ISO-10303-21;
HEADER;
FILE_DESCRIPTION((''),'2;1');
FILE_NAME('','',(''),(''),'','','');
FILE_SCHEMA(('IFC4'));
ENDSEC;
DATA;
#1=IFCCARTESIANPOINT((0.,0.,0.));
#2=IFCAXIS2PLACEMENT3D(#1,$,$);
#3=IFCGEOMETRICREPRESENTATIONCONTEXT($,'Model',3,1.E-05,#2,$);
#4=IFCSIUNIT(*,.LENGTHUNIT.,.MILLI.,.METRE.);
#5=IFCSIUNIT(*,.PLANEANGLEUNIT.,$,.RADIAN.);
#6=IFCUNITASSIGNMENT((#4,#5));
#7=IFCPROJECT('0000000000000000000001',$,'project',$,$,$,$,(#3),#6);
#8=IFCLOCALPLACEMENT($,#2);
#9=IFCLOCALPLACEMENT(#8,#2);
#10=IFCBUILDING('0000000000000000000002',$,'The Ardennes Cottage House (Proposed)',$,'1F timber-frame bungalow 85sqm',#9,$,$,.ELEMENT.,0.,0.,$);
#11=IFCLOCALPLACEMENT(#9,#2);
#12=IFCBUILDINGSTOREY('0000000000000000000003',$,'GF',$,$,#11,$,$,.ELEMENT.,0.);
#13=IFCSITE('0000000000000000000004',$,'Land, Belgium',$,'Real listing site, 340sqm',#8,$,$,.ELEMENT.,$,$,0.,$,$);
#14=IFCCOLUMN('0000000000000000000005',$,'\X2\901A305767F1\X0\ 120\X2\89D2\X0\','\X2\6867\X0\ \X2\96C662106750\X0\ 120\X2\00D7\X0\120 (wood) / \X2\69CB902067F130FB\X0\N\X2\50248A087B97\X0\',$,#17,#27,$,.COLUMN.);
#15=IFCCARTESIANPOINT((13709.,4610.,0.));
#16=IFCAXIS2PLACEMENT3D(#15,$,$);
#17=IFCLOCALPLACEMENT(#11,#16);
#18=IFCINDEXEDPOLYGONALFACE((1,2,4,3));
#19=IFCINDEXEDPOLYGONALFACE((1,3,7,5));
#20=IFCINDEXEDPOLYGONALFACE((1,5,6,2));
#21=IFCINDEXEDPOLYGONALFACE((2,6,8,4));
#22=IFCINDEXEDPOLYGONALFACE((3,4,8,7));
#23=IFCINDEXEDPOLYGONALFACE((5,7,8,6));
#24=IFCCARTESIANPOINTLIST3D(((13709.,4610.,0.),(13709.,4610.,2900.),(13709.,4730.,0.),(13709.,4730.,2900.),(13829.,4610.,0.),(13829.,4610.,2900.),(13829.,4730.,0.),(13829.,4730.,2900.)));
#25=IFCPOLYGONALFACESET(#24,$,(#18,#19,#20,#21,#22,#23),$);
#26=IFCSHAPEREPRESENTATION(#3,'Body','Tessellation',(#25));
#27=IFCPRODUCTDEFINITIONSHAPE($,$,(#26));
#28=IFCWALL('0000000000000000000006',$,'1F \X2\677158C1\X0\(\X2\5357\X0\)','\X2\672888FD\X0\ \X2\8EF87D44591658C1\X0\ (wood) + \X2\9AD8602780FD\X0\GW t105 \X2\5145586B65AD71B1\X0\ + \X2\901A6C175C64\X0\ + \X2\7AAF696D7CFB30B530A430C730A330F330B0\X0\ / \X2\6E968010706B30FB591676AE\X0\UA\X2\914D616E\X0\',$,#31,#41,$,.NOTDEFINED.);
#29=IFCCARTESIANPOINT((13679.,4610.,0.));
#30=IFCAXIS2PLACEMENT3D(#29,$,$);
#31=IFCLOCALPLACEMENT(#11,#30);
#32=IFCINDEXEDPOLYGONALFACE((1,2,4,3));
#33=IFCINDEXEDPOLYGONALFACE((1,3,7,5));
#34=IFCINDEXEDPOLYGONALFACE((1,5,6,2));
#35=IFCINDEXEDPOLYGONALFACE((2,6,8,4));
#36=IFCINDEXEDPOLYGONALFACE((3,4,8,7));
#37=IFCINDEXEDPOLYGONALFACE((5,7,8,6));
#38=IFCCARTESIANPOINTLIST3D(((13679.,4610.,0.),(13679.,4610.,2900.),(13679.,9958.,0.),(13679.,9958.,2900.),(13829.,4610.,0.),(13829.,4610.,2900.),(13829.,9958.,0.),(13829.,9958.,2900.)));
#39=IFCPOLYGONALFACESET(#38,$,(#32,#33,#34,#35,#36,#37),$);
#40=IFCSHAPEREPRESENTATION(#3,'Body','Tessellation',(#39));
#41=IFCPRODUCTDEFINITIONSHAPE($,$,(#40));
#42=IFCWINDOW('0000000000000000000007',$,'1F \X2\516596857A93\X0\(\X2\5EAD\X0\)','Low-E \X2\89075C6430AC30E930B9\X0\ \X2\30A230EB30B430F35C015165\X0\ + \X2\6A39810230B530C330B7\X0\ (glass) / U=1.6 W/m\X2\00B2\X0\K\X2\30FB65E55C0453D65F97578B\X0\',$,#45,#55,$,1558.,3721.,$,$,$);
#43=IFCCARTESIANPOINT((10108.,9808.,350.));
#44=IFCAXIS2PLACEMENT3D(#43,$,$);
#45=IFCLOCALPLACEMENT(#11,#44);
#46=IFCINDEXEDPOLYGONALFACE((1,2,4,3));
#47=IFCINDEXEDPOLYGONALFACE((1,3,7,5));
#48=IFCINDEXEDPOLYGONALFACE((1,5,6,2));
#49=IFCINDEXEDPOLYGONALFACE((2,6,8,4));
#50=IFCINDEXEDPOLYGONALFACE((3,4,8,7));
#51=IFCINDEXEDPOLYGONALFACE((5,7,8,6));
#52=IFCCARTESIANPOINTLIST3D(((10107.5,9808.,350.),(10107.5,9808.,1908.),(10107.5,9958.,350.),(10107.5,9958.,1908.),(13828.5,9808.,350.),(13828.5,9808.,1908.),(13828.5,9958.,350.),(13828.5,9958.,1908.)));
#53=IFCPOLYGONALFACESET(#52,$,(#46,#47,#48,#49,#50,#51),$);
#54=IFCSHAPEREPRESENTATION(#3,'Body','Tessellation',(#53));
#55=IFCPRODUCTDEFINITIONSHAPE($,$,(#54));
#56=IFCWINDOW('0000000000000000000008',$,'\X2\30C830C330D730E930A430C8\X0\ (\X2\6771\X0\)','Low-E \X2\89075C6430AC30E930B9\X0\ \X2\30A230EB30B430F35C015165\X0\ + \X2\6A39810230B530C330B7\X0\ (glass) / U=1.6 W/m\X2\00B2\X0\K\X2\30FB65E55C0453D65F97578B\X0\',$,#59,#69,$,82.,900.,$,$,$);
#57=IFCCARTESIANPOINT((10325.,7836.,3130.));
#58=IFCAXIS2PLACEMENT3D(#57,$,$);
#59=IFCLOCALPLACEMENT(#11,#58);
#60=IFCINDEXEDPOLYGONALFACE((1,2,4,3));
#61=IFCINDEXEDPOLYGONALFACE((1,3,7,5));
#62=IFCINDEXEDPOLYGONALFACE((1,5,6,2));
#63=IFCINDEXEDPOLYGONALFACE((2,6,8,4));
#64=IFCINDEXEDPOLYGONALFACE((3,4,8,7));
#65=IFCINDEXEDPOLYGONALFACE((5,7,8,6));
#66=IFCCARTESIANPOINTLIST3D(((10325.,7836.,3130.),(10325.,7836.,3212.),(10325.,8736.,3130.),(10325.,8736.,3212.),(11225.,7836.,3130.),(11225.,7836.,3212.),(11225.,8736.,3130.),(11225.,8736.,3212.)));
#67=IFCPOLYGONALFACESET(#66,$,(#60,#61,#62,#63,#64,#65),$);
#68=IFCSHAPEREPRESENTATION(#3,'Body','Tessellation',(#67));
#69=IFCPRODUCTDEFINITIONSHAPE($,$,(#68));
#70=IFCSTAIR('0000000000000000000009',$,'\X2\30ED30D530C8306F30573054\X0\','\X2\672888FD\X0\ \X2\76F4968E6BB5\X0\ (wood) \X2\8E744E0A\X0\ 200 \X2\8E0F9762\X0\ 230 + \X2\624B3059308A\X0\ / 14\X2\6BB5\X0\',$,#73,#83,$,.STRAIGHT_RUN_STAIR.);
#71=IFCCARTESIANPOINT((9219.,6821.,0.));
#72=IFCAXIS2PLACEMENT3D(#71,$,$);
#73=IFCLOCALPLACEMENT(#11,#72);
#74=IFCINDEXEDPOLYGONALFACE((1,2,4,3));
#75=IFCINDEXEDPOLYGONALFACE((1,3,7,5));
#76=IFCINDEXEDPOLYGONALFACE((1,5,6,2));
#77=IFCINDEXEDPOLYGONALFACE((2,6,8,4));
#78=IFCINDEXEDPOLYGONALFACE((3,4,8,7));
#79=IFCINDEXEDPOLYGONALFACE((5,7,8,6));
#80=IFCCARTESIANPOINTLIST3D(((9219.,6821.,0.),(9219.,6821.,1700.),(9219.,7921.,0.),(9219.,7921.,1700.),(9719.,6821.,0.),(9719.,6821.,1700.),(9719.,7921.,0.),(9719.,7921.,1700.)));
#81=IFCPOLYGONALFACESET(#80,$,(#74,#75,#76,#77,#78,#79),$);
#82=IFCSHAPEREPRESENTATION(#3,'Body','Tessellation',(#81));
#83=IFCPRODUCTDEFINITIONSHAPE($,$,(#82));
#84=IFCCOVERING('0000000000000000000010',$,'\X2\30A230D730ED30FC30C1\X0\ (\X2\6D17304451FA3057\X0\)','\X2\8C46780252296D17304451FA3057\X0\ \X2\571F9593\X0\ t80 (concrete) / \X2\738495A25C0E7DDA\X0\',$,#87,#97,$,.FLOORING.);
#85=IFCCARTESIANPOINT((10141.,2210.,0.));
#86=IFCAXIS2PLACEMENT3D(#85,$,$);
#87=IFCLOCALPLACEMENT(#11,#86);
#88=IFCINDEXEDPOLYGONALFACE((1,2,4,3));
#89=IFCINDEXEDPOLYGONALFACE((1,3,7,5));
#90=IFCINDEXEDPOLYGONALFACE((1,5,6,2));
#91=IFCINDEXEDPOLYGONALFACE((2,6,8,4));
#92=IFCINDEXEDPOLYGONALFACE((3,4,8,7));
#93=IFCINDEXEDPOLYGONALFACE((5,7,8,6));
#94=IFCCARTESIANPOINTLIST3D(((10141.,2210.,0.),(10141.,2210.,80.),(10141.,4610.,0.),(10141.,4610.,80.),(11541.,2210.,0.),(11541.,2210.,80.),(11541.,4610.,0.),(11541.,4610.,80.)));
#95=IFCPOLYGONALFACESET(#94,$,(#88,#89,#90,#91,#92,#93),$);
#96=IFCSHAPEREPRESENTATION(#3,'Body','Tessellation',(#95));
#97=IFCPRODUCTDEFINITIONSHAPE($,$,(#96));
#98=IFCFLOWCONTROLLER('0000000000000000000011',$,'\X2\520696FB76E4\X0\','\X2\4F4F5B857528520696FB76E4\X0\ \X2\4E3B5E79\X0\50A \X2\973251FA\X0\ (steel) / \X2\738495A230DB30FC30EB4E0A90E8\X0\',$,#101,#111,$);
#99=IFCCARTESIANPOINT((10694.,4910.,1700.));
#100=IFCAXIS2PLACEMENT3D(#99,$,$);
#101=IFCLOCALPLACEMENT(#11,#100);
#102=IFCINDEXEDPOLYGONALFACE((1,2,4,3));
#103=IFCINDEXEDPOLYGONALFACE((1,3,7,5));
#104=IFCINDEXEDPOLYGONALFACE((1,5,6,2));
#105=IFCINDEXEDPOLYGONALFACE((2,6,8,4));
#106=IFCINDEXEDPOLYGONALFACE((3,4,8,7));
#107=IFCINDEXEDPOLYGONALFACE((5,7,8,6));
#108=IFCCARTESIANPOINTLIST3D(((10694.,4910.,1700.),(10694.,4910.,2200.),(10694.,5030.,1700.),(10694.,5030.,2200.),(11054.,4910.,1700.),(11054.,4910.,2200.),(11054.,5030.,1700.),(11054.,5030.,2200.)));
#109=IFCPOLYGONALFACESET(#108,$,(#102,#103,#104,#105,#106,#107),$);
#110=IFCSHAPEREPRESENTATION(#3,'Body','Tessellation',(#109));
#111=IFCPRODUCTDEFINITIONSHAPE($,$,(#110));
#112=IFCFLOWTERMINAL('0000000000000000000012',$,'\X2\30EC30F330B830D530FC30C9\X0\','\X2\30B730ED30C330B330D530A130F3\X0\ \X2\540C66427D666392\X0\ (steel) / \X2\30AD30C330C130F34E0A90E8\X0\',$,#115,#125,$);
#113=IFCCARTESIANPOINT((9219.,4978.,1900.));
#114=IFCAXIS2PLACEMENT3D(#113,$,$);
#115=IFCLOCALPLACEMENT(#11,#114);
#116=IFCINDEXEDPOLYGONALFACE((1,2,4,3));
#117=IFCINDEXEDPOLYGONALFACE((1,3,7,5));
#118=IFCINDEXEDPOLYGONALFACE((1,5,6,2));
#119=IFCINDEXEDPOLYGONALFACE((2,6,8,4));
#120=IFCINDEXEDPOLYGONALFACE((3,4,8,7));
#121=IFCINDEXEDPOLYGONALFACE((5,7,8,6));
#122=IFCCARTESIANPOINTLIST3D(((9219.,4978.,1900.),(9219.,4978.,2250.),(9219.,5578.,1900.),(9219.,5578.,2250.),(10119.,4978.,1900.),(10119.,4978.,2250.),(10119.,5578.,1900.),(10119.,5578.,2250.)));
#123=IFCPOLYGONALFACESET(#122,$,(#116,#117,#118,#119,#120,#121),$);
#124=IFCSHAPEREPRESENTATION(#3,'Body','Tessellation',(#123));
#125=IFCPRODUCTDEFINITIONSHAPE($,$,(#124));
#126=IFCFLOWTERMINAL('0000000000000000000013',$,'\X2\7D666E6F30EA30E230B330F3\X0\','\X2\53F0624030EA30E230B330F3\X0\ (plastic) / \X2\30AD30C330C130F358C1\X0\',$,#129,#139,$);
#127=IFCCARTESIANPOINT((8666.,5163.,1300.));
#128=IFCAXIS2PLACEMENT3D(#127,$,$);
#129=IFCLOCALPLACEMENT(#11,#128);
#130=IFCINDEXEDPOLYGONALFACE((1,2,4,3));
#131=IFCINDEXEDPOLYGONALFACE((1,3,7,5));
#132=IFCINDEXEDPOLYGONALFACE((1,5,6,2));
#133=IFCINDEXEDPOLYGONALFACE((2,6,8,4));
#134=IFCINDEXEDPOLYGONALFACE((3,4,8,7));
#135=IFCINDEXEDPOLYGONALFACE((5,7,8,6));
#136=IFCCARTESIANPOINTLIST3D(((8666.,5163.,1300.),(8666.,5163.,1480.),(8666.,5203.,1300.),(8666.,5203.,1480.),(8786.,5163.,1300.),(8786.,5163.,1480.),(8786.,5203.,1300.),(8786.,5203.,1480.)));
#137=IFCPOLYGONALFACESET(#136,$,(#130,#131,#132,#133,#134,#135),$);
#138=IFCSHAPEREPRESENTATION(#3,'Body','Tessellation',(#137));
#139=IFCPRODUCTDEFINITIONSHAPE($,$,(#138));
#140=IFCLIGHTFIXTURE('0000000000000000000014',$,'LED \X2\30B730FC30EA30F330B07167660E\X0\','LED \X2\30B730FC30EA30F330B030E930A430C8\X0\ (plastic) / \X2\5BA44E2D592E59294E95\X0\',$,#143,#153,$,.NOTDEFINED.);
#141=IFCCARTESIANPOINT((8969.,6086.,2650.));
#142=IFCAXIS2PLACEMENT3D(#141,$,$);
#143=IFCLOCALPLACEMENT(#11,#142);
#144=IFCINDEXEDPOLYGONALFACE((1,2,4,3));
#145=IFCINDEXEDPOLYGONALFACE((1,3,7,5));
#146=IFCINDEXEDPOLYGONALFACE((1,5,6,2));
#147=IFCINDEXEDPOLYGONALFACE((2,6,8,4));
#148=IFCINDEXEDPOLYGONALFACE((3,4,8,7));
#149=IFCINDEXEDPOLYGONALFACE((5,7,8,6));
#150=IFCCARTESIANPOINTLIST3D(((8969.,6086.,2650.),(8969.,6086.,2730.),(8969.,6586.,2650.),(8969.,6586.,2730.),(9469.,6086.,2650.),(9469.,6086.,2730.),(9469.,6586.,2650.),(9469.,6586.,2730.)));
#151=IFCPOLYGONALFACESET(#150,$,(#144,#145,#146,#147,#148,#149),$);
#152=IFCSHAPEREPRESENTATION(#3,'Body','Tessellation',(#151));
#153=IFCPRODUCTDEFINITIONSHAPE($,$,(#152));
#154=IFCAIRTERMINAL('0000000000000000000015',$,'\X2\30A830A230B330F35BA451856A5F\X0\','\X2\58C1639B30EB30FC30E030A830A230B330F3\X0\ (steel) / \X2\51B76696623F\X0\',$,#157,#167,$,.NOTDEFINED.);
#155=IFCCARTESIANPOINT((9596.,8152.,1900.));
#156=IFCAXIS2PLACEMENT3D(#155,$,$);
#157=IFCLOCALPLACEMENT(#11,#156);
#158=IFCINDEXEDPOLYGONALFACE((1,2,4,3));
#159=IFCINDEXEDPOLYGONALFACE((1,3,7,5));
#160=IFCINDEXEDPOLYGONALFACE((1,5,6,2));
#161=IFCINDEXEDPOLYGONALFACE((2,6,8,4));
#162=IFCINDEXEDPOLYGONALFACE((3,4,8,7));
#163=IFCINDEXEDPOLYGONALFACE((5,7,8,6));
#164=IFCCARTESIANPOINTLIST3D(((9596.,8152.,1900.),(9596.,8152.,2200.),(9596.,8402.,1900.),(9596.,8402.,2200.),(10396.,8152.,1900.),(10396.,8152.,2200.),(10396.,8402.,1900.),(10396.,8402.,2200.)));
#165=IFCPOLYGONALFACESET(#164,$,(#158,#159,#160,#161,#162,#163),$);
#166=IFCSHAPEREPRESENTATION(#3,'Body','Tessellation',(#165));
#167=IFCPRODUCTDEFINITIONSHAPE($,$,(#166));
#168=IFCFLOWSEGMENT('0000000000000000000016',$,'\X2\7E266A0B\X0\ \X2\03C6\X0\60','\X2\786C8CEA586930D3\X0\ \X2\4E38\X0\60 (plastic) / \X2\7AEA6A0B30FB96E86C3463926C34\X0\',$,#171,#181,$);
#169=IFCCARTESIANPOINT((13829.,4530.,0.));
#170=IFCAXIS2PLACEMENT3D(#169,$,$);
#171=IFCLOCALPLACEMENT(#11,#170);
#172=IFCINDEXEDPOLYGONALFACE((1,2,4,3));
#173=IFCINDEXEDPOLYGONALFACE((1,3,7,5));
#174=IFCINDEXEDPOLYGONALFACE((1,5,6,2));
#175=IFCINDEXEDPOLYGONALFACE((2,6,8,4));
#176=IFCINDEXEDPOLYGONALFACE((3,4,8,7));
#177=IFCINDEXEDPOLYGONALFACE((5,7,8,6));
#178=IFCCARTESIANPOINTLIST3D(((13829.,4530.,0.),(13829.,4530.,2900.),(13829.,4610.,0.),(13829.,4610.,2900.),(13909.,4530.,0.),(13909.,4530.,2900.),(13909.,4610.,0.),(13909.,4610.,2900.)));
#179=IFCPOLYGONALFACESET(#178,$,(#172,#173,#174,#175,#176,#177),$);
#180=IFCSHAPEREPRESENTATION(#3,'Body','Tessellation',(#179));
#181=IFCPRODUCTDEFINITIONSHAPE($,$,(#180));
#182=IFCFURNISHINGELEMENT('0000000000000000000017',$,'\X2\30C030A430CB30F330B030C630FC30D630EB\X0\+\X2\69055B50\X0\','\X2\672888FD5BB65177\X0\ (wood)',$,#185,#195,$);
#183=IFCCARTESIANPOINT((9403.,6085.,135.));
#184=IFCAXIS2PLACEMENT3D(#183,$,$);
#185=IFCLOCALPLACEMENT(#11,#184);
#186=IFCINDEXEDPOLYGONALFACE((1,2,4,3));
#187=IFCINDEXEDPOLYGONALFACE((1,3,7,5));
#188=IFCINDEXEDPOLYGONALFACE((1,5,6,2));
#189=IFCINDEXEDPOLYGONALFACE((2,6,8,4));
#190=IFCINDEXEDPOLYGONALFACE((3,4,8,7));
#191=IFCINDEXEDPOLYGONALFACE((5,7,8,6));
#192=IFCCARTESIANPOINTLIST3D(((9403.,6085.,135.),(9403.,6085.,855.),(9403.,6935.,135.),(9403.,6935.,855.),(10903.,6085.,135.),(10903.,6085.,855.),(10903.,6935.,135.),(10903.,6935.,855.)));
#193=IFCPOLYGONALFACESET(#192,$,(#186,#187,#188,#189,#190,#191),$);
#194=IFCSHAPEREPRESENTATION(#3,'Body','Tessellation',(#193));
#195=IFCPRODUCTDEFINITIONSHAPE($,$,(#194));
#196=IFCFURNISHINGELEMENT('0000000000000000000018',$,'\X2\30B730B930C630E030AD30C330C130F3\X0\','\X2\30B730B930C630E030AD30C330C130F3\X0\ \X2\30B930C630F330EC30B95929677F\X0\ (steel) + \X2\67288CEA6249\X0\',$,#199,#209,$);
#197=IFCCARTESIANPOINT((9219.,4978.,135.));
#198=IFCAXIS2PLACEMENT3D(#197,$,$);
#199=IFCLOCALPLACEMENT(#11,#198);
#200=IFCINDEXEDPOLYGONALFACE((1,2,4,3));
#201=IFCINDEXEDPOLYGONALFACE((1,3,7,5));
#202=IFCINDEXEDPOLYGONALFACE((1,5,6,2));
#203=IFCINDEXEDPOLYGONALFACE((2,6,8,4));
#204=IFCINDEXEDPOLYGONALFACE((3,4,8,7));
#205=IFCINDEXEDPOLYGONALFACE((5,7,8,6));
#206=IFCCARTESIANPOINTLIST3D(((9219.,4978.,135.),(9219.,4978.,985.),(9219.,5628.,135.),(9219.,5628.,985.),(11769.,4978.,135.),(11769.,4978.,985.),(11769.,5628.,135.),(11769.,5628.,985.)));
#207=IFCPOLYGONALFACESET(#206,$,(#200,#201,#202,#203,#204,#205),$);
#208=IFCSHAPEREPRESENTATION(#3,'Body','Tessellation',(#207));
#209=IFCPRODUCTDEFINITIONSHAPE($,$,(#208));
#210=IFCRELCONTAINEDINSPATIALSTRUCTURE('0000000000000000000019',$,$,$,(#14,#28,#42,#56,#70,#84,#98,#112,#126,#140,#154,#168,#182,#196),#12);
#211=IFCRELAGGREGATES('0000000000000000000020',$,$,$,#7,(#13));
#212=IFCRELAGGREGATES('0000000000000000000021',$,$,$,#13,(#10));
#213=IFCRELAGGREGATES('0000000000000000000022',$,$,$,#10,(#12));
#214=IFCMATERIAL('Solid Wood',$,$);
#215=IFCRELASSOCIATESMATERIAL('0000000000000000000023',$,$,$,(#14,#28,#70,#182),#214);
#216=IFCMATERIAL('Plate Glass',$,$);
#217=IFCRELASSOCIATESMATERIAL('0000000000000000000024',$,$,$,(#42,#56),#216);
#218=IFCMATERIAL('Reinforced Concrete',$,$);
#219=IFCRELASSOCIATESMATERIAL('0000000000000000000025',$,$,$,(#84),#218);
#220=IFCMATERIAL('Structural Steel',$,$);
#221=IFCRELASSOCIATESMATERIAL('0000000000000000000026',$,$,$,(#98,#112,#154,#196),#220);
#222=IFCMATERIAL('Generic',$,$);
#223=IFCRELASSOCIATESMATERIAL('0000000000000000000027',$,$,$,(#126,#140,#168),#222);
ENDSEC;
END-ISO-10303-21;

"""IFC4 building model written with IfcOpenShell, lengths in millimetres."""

from ifc_helpers import new_model, si_unit, frame, frame_2d, origin, place, context, project, spatial, rectangle, extrude, material, element, fill, save


model = new_model("IFC4")

# Units and contexts
model_context = context("Model", 3, precision=1e-05, world=origin())
ifc_project = project(units=[si_unit("LENGTHUNIT", "METRE", prefix="MILLI"), si_unit("PLANEANGLEUNIT", "RADIAN")], contexts=[model_context])

# Site, building, storey
site_placement = place(None, origin())
site = spatial("IfcSite", under=ifc_project, at=site_placement, Name="Land, Belgium", ObjectType="Real listing site, 340sqm", CompositionType="ELEMENT", RefElevation=0.0)
building_placement = place(site_placement, origin())
building = spatial("IfcBuilding", under=site, at=building_placement, Name="The Ardennes Cottage House (Proposed)", ObjectType="1F timber-frame bungalow 85sqm", CompositionType="ELEMENT", ElevationOfRefHeight=0.0, ElevationOfTerrain=0.0)
storey_placement = place(building_placement, origin())
storey = spatial("IfcBuildingStorey", under=building, at=storey_placement, Name="GF", CompositionType="ELEMENT", Elevation=0.0)

# Column
ifc_material_1 = material(Name="Solid Wood")
column_1_placement = place(storey_placement, frame((13709.0, 4610.0, 0.0)))
element("IfcColumn", 1, at=column_1_placement, inside=storey, material=ifc_material_1, Name="通し柱 120角", Description="桧 集成材 120×120 (wood) / 構造柱・N値計算", PredefinedType="COLUMN", context=model_context, shape_type="SweptSolid", body=[
    extrude(rectangle(XDim=120.0, YDim=120.0, at=frame_2d((60.0, 60.0))), frame((13709.0, 4610.0, 0.0)), (0.0, 0.0, 1.0), 2900.0),
])

# Wall, opening, window
wall_1_placement = place(storey_placement, frame((13679.0, 4610.0, 0.0)))
wall_1 = element("IfcWall", 2, at=wall_1_placement, inside=storey, material=ifc_material_1, Name="1F 東壁(南)", Description="木製 軸組外壁 (wood) + 高性能GW t105 充填断熱 + 通気層 + 窯業系サイディング / 準耐火・外皮UA配慮", PredefinedType="NOTDEFINED", context=model_context, shape_type="SweptSolid", body=[
    extrude(rectangle(XDim=150.0, YDim=5348.0, at=frame_2d((75.0, 2674.0))), frame((13679.0, 4610.0, 0.0)), (0.0, 0.0, 1.0), 2900.0),
])
opening_placement = place(storey_placement, frame((10108.0, 9808.0, 350.0)))
opening = element("IfcOpeningElement", 3, at=opening_placement, cuts=wall_1, PredefinedType="NOTDEFINED", context=model_context, shape_type="SweptSolid", body=[
    extrude(rectangle(XDim=3721.0, YDim=150.0, at=frame_2d((1860.0, 75.0))), frame((10108.0, 9808.0, 350.0)), (0.0, 0.0, 1.0), 1558.0),
])
ifc_material_2 = material(Name="Plate Glass")
window_1_placement = place(storey_placement, frame((10108.0, 9808.0, 350.0)))
window_1 = element("IfcWindow", 4, at=window_1_placement, inside=storey, material=ifc_material_2, Name="1F 入隅窓(庭)", Description="Low-E 複層ガラス アルゴン封入 + 樹脂サッシ (glass) / U=1.6 W/m²K・日射取得型", OverallHeight=1558.0, OverallWidth=3721.0, context=model_context, shape_type="SweptSolid", body=[
    extrude(rectangle(XDim=3721.0, YDim=150.0, at=frame_2d((1860.0, 75.0))), frame((10108.0, 9808.0, 350.0)), (0.0, 0.0, 1.0), 1558.0),
])
fill(opening, window_1)

# Window
window_2_placement = place(storey_placement, frame((10325.0, 7836.0, 3130.0)))
element("IfcWindow", 5, at=window_2_placement, inside=storey, material=ifc_material_2, Name="トップライト (東)", Description="Low-E 複層ガラス アルゴン封入 + 樹脂サッシ (glass) / U=1.6 W/m²K・日射取得型", OverallHeight=82.0, OverallWidth=900.0, context=model_context, shape_type="SweptSolid", body=[
    extrude(rectangle(XDim=900.0, YDim=900.0, at=frame_2d((450.0, 450.0))), frame((10325.0, 7836.0, 3130.0)), (0.0, 0.0, 1.0), 82.0),
])

# Stair
stair_placement = place(storey_placement, frame((9219.0, 6821.0, 0.0)))
element("IfcStair", 6, at=stair_placement, inside=storey, material=ifc_material_1, Name="ロフトはしご", Description="木製 直階段 (wood) 蹴上 200 踏面 230 + 手すり / 14段", PredefinedType="STRAIGHT_RUN_STAIR", context=model_context, shape_type="SweptSolid", body=[
    extrude(rectangle(XDim=500.0, YDim=1100.0, at=frame_2d((250.0, 550.0))), frame((9219.0, 6821.0, 0.0)), (0.0, 0.0, 1.0), 1700.0),
])

# Covering
ifc_material_3 = material(Name="Reinforced Concrete")
covering_placement = place(storey_placement, frame((10141.0, 2210.0, 0.0)))
element("IfcCovering", 7, at=covering_placement, inside=storey, material=ifc_material_3, Name="アプローチ (洗い出し)", Description="豆砂利洗い出し 土間 t80 (concrete) / 玄関導線", PredefinedType="FLOORING", context=model_context, shape_type="SweptSolid", body=[
    extrude(rectangle(XDim=1400.0, YDim=2400.0, at=frame_2d((700.0, 1200.0))), frame((10141.0, 2210.0, 0.0)), (0.0, 0.0, 1.0), 80.0),
])

# Flow controller
ifc_material_4 = material(Name="Structural Steel")
flow_controller_placement = place(storey_placement, frame((10694.0, 4910.0, 1700.0)))
element("IfcFlowController", 8, at=flow_controller_placement, inside=storey, material=ifc_material_4, Name="分電盤", Description="住宅用分電盤 主幹50A 露出 (steel) / 玄関ホール上部", context=model_context, shape_type="SweptSolid", body=[
    extrude(rectangle(XDim=360.0, YDim=120.0, at=frame_2d((180.0, 60.0))), frame((10694.0, 4910.0, 1700.0)), (0.0, 0.0, 1.0), 500.0),
])

# Flow terminals
flow_terminal_1_placement = place(storey_placement, frame((9219.0, 4978.0, 1900.0)))
element("IfcFlowTerminal", 9, at=flow_terminal_1_placement, inside=storey, material=ifc_material_4, Name="レンジフード", Description="シロッコファン 同時給排 (steel) / キッチン上部", context=model_context, shape_type="SweptSolid", body=[
    extrude(rectangle(XDim=900.0, YDim=600.0, at=frame_2d((450.0, 300.0))), frame((9219.0, 4978.0, 1900.0)), (0.0, 0.0, 1.0), 350.0),
])
ifc_material_5 = material(Name="Generic")
flow_terminal_2_placement = place(storey_placement, frame((8666.0, 5163.0, 1300.0)))
element("IfcFlowTerminal", 10, at=flow_terminal_2_placement, inside=storey, material=ifc_material_5, Name="給湯リモコン", Description="台所リモコン (plastic) / キッチン壁", context=model_context, shape_type="SweptSolid", body=[
    extrude(rectangle(XDim=120.0, YDim=40.0, at=frame_2d((60.0, 20.0))), frame((8666.0, 5163.0, 1300.0)), (0.0, 0.0, 1.0), 180.0),
])

# Light fixture
light_fixture_placement = place(storey_placement, frame((8969.0, 6086.0, 2650.0)))
element("IfcLightFixture", 11, at=light_fixture_placement, inside=storey, material=ifc_material_5, Name="LED シーリング照明", Description="LED シーリングライト (plastic) / 室中央天井", PredefinedType="NOTDEFINED", context=model_context, shape_type="SweptSolid", body=[
    extrude(rectangle(XDim=500.0, YDim=500.0, at=frame_2d((250.0, 250.0))), frame((8969.0, 6086.0, 2650.0)), (0.0, 0.0, 1.0), 80.0),
])

# Air terminal
air_terminal_placement = place(storey_placement, frame((9596.0, 8152.0, 1900.0)))
element("IfcAirTerminal", 12, at=air_terminal_placement, inside=storey, material=ifc_material_4, Name="エアコン室内機", Description="壁掛ルームエアコン (steel) / 冷暖房", PredefinedType="NOTDEFINED", context=model_context, shape_type="SweptSolid", body=[
    extrude(rectangle(XDim=800.0, YDim=250.0, at=frame_2d((400.0, 125.0))), frame((9596.0, 8152.0, 1900.0)), (0.0, 0.0, 1.0), 300.0),
])

# Flow segment
flow_segment_placement = place(storey_placement, frame((13829.0, 4530.0, 0.0)))
element("IfcFlowSegment", 13, at=flow_segment_placement, inside=storey, material=ifc_material_5, Name="縦樋 φ60", Description="硬質塩ビ 丸60 (plastic) / 竪樋・雨水排水", context=model_context, shape_type="SweptSolid", body=[
    extrude(rectangle(XDim=80.0, YDim=80.0, at=frame_2d((40.0, 40.0))), frame((13829.0, 4530.0, 0.0)), (0.0, 0.0, 1.0), 2900.0),
])

# Furnishing elements
furnishing_1_placement = place(storey_placement, frame((9403.0, 6085.0, 135.0)))
element("IfcFurnishingElement", 14, at=furnishing_1_placement, inside=storey, material=ifc_material_1, Name="ダイニングテーブル+椅子", Description="木製家具 (wood)", context=model_context, shape_type="SweptSolid", body=[
    extrude(rectangle(XDim=1500.0, YDim=850.0, at=frame_2d((750.0, 425.0))), frame((9403.0, 6085.0, 135.0)), (0.0, 0.0, 1.0), 720.0),
])
furnishing_2_placement = place(storey_placement, frame((9219.0, 4978.0, 135.0)))
element("IfcFurnishingElement", 15, at=furnishing_2_placement, inside=storey, material=ifc_material_4, Name="システムキッチン", Description="システムキッチン ステンレス天板 (steel) + 木質扉", context=model_context, shape_type="SweptSolid", body=[
    extrude(rectangle(XDim=2550.0, YDim=650.0, at=frame_2d((1275.0, 325.0))), frame((9219.0, 4978.0, 135.0)), (0.0, 0.0, 1.0), 850.0),
])

save(model, "model.ifc")
